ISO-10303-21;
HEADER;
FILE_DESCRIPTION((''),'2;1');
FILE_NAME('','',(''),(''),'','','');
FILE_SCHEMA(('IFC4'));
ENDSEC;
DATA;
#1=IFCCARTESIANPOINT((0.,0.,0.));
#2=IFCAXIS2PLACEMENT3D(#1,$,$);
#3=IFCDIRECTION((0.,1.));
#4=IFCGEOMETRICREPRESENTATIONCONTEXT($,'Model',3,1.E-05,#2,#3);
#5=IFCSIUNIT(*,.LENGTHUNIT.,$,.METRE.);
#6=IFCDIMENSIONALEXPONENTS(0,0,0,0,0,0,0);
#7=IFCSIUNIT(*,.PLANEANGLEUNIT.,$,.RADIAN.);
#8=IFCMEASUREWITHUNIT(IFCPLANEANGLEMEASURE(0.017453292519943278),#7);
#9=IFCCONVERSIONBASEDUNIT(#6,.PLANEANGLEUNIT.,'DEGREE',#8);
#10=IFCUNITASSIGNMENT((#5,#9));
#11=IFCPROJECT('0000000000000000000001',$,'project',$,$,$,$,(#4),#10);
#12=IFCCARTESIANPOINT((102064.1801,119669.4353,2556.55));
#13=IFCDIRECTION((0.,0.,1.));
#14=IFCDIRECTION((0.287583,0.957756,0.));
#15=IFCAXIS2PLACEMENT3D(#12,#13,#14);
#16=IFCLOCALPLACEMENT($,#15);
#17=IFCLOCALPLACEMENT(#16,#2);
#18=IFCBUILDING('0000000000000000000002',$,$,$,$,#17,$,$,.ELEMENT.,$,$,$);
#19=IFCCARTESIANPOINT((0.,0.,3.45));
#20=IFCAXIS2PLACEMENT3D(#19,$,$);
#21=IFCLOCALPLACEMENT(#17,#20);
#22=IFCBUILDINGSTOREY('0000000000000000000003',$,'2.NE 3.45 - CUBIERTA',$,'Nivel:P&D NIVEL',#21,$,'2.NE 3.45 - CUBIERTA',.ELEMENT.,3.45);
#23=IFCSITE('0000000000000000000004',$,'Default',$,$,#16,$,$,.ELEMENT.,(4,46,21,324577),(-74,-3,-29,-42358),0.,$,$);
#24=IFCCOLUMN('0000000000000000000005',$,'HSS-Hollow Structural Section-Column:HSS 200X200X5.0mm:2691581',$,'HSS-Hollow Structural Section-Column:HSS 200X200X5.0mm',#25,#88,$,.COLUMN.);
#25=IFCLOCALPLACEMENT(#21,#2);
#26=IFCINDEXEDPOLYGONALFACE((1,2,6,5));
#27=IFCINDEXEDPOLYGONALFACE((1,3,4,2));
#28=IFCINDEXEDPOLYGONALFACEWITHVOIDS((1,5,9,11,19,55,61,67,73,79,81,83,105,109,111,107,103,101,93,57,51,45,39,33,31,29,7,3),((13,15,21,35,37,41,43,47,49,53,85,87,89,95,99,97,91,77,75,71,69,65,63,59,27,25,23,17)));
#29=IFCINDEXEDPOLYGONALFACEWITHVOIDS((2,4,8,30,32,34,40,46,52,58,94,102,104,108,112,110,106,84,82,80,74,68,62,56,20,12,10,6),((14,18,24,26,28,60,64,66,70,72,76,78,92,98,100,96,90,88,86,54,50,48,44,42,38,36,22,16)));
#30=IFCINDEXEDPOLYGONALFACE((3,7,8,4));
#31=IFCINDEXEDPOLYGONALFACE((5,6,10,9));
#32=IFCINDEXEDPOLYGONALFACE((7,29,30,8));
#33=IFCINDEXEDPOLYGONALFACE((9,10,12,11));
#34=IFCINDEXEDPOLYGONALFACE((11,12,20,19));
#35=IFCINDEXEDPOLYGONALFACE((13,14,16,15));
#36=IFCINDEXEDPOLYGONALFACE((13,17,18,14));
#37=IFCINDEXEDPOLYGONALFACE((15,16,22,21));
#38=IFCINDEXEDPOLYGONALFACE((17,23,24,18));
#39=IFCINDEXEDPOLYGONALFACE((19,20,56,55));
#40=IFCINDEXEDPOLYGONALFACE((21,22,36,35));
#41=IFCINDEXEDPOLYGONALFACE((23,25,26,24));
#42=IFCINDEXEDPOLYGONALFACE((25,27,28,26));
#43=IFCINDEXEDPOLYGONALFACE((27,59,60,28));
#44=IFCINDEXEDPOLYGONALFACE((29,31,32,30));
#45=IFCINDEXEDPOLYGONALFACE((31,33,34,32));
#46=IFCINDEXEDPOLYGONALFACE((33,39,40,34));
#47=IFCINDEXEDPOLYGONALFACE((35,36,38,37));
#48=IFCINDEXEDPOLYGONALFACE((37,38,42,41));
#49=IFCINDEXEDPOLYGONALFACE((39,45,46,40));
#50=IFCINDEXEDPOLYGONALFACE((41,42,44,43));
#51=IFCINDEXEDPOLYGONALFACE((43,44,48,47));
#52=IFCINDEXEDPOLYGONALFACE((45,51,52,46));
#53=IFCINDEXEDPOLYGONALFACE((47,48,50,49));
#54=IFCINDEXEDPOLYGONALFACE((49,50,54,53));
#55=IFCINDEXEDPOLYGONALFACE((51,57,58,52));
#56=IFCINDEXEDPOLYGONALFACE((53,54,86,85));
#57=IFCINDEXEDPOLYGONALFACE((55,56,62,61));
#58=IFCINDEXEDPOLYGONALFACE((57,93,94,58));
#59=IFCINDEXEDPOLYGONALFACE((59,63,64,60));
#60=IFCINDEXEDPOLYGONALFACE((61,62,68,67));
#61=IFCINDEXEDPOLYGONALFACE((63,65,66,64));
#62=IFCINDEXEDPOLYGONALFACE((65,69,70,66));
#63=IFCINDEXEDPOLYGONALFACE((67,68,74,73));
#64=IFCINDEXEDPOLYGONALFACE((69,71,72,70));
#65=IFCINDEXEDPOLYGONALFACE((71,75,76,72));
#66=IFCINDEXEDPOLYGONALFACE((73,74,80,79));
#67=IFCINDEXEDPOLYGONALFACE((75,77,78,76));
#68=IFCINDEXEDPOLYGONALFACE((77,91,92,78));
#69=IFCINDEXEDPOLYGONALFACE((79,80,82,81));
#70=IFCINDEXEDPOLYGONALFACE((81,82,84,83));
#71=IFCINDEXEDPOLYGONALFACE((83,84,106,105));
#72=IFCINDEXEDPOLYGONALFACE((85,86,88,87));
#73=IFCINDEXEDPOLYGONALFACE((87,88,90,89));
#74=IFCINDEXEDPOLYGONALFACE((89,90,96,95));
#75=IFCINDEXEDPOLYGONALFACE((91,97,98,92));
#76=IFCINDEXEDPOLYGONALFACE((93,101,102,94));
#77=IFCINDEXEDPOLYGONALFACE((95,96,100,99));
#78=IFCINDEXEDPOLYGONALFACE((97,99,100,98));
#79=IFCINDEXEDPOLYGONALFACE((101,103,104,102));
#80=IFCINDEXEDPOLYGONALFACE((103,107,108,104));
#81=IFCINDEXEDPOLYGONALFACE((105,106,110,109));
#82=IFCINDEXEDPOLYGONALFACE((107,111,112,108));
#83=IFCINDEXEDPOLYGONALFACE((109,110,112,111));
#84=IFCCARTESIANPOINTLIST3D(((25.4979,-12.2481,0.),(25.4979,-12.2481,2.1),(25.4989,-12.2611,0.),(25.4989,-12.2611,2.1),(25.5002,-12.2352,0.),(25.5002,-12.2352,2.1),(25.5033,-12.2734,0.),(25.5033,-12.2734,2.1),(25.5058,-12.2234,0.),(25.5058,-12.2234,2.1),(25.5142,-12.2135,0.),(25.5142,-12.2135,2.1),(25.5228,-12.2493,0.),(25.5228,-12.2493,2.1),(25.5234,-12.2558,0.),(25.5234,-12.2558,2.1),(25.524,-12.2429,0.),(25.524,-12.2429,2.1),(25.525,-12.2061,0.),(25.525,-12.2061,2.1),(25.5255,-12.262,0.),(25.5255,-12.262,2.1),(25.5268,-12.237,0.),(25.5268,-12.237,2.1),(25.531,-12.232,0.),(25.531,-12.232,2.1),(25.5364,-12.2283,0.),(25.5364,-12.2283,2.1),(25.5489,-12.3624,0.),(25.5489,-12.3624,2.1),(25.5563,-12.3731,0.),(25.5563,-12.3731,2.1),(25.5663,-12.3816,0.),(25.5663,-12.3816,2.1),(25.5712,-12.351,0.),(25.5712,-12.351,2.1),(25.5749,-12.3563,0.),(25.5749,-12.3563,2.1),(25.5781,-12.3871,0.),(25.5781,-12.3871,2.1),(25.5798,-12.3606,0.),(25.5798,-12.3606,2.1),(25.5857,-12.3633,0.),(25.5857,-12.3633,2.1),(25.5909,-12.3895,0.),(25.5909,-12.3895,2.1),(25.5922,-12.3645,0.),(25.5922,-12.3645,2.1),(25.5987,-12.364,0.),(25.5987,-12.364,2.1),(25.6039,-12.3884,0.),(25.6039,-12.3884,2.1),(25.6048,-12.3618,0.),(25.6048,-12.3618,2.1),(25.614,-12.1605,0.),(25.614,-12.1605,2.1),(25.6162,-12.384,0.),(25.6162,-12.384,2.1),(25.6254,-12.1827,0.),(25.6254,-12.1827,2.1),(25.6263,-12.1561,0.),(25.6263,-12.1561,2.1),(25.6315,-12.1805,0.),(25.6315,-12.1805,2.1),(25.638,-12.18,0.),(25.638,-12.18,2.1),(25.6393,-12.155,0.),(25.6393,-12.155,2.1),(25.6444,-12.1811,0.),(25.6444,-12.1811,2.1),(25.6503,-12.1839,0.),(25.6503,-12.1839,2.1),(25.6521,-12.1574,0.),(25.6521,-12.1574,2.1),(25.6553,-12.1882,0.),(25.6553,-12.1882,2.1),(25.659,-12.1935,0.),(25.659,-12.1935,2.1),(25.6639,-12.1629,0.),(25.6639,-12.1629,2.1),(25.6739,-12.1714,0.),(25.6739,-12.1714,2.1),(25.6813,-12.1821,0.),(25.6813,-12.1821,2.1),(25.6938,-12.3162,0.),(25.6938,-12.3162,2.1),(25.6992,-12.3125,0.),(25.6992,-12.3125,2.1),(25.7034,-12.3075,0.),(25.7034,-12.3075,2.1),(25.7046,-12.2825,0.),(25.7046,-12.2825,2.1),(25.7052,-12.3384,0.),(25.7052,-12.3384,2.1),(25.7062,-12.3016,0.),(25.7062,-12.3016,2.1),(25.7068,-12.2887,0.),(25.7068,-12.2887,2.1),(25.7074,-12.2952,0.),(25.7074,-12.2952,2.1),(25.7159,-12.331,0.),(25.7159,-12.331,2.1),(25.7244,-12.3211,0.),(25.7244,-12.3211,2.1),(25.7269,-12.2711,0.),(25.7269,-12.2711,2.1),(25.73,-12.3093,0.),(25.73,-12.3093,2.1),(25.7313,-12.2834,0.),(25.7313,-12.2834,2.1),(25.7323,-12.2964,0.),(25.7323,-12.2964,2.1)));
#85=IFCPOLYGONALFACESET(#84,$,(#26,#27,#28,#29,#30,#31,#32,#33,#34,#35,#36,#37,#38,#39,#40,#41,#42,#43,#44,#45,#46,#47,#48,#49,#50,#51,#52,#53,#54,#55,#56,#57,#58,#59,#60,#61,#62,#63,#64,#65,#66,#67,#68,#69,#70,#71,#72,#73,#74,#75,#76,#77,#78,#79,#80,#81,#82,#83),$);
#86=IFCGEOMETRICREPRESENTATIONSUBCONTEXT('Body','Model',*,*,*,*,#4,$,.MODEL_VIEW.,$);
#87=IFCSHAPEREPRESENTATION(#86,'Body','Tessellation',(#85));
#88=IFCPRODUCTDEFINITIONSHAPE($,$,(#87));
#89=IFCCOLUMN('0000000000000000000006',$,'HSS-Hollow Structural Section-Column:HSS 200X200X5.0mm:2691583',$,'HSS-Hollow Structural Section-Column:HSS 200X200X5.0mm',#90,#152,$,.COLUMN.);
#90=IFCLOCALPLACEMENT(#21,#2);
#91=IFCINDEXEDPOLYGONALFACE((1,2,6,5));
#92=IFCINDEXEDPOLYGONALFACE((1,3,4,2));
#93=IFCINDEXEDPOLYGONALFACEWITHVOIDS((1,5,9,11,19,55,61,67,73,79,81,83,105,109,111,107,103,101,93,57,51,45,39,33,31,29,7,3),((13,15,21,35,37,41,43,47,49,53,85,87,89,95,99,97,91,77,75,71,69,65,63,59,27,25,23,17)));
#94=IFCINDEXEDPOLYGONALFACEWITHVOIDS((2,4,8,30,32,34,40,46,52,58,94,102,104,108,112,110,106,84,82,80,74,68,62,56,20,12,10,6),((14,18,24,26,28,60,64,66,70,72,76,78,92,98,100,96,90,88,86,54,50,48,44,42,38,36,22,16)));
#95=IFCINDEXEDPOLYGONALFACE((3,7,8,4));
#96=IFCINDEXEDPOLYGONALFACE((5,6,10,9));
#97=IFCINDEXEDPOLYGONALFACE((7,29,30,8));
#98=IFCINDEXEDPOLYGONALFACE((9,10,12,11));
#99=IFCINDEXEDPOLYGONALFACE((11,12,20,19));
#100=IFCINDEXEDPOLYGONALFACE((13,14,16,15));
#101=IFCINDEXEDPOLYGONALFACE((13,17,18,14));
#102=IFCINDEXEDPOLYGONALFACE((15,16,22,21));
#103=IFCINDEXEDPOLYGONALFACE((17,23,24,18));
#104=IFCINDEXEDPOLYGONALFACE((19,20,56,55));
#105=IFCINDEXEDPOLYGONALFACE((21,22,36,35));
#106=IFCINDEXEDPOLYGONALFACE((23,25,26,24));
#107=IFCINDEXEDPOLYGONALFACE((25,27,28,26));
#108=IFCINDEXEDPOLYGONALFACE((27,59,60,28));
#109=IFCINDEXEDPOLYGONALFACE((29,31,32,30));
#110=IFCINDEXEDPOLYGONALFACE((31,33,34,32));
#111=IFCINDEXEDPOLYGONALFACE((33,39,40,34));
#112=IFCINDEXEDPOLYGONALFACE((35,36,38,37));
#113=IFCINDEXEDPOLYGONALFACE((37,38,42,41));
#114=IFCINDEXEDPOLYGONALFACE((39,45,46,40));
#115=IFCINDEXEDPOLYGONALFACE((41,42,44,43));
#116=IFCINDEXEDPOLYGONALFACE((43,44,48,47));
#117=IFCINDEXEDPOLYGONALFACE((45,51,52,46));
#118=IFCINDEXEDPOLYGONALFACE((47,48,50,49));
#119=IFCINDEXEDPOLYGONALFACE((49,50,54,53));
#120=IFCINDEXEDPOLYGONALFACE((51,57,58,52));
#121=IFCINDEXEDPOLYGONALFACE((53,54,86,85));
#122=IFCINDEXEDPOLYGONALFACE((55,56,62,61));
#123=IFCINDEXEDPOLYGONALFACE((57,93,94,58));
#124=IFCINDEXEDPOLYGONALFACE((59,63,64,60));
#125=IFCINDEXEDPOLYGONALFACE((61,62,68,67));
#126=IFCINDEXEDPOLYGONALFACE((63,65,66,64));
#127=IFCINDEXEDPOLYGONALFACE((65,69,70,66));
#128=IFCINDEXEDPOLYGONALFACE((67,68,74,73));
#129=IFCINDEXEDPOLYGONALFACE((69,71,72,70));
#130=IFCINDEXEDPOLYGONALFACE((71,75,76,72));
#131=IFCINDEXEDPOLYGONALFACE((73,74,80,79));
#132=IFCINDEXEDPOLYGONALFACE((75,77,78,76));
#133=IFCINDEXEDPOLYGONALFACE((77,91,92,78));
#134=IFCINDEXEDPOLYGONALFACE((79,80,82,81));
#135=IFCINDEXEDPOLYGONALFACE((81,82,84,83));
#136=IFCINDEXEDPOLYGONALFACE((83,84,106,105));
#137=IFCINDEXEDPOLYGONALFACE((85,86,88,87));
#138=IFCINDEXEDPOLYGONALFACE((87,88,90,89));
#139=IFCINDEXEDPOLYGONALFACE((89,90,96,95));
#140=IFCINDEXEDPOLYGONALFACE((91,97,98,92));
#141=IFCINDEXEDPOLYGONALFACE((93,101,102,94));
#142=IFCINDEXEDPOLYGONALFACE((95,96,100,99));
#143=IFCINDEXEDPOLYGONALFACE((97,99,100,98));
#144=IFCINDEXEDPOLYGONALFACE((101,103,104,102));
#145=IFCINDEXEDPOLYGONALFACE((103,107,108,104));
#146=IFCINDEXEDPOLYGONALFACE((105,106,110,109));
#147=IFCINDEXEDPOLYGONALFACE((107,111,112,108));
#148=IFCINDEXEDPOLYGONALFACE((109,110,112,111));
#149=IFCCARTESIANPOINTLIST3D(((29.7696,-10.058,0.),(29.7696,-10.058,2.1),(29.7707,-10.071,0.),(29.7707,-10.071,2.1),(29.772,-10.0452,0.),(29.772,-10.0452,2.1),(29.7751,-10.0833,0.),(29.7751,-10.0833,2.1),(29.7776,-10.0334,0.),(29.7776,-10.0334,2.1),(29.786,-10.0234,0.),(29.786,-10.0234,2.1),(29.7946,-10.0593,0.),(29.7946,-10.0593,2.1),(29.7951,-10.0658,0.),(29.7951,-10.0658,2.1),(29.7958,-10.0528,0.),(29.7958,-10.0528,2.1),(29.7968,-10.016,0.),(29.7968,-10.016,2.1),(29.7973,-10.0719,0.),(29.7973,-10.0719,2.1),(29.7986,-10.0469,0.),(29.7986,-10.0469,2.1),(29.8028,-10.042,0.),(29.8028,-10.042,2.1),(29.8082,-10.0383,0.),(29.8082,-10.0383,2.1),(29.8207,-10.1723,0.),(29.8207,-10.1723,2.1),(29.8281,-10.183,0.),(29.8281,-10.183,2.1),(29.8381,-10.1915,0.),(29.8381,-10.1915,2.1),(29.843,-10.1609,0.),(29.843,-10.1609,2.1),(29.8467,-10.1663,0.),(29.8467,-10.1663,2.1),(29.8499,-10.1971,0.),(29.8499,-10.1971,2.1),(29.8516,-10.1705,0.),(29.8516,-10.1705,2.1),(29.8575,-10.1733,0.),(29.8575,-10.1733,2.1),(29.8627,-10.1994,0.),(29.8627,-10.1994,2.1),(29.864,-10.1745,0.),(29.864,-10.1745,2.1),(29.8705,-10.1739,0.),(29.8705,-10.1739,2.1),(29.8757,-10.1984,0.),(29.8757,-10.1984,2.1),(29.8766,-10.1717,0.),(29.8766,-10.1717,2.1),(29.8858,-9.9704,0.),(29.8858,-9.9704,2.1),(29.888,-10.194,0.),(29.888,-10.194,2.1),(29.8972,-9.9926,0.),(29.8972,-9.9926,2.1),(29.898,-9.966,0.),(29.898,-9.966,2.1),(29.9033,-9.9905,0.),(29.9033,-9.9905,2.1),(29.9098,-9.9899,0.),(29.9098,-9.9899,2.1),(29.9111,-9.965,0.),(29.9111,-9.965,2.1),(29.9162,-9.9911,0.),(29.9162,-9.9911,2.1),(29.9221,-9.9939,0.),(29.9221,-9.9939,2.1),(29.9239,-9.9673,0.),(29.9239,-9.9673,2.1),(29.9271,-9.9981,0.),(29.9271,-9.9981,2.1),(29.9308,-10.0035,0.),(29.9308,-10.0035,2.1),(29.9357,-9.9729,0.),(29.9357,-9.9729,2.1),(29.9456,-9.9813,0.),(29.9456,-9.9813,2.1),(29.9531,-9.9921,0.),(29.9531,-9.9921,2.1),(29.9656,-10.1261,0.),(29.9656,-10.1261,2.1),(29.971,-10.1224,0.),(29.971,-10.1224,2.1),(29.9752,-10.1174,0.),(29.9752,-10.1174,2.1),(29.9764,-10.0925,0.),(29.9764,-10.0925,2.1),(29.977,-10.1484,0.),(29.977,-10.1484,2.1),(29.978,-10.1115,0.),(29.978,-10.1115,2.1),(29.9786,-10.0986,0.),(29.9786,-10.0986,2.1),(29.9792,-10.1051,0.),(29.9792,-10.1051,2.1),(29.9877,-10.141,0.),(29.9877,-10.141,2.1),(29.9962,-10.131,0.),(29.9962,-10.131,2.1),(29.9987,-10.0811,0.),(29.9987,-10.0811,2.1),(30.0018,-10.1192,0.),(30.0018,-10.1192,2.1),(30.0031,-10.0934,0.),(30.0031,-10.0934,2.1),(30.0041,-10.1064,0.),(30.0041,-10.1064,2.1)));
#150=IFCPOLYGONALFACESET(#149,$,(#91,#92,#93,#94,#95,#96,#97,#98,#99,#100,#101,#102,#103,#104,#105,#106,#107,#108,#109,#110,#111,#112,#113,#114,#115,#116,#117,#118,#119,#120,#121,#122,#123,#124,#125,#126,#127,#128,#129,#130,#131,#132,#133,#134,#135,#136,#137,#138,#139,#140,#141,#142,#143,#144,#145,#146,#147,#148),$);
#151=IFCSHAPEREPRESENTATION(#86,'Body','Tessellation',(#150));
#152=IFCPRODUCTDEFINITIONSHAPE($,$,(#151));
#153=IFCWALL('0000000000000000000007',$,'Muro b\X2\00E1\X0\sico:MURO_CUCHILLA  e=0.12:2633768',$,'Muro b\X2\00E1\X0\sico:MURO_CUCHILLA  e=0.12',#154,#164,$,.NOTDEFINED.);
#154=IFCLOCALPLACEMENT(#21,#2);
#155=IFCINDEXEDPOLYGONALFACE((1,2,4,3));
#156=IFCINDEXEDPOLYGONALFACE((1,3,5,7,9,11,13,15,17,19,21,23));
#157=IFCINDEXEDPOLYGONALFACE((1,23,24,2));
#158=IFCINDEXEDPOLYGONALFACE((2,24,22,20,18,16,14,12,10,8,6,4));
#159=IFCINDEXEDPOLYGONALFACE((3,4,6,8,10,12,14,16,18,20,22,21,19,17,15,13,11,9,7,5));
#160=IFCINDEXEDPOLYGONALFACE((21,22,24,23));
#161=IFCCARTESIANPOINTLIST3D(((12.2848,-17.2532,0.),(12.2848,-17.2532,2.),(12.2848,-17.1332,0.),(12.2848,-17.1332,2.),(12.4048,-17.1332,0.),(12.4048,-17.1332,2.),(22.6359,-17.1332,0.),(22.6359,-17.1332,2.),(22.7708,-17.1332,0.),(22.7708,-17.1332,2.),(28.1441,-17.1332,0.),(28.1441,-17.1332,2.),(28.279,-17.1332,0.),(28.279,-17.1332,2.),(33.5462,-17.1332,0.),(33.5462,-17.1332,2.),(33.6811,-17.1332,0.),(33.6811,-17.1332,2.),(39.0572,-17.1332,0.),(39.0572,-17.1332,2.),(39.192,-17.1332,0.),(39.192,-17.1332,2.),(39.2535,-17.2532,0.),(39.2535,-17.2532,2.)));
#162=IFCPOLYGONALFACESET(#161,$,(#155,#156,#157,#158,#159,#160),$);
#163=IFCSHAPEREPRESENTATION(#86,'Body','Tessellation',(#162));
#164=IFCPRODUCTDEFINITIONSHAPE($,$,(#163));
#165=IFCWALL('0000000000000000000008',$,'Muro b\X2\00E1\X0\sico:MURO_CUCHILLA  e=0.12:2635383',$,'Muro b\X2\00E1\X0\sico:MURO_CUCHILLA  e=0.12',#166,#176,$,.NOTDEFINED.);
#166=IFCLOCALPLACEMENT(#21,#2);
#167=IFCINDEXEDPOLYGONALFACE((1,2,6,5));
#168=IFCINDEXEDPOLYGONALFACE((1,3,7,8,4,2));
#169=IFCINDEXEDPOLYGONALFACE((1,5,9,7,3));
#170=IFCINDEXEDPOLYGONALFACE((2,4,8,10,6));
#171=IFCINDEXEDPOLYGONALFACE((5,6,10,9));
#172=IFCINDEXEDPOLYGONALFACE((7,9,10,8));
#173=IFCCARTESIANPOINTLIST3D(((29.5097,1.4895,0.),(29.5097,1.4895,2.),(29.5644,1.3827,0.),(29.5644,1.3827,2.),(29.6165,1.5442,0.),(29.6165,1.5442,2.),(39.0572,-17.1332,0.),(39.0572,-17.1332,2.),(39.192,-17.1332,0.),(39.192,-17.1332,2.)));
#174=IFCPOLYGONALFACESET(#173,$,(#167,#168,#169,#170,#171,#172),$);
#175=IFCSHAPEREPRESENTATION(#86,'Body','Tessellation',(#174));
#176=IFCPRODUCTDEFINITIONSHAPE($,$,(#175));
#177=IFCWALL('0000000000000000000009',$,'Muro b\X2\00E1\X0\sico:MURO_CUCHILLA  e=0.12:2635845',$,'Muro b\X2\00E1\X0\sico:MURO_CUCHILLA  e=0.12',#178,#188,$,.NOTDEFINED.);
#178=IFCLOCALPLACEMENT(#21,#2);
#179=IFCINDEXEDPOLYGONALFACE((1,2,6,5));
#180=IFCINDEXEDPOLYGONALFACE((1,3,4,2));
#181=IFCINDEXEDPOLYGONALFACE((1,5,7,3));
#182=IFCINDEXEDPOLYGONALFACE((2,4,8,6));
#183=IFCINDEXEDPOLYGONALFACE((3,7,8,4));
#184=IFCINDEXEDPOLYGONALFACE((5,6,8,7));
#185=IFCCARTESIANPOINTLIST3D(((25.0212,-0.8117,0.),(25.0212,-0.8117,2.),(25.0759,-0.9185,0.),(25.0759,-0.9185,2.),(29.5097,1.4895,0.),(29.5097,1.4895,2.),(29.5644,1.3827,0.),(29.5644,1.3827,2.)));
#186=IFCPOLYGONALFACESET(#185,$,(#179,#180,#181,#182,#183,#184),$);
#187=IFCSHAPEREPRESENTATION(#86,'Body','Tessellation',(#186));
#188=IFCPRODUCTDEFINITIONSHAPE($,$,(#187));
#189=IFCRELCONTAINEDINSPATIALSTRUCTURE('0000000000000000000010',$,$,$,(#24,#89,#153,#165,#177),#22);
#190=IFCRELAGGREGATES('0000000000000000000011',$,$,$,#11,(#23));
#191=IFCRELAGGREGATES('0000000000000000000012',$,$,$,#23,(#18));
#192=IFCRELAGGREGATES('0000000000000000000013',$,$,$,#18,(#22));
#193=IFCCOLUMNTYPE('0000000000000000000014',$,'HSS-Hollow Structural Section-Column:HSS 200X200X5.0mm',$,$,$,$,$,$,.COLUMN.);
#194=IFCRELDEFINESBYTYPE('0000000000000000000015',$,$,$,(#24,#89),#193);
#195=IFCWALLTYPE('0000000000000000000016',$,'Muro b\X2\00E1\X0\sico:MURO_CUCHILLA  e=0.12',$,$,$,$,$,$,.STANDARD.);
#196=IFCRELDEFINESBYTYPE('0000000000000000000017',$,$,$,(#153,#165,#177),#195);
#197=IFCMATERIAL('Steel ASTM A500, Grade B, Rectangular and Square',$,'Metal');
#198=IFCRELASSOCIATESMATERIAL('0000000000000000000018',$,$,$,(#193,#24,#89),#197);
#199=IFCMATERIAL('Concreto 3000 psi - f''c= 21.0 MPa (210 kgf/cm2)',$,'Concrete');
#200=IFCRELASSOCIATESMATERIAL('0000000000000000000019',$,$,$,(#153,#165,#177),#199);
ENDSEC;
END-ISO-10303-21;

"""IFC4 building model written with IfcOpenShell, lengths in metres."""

from ifc_helpers import new_model, entity, si_unit, converted_unit, direction, frame, origin, place, context, subcontext, project, spatial, line, arc, indexed_curve, outline, extrude, source, transform, mapped, material, type_object, type_shapes, element, save


model = new_model("IFC4")

# Units and contexts
model_context = context("Model", 3, precision=1e-05, world=origin(), true_north=direction((0.0, 1.0)))
body_context = subcontext(model_context, "Body", "Model", "MODEL_VIEW")
ifc_project = project(units=[si_unit("LENGTHUNIT", "METRE"), converted_unit("PLANEANGLEUNIT", "DEGREE", entity("IfcPlaneAngleMeasure", 0.017453292519943278), si_unit("PLANEANGLEUNIT", "RADIAN"), dimensions=[0, 0, 0, 0, 0, 0, 0])], contexts=[model_context])

# Site, building, storey
site_placement = place(None, frame((102064.1801, 119669.4353, 2556.55), z_axis=(0.0, 0.0, 1.0), x_axis=(0.287583, 0.957756, 0.0)))
site = spatial("IfcSite", under=ifc_project, at=site_placement, Name="Default", CompositionType="ELEMENT", RefLatitude=(4, 46, 21, 324577), RefLongitude=(-74, -3, -29, -42358), RefElevation=0.0)
building_placement = place(site_placement, origin())
building = spatial("IfcBuilding", under=site, at=building_placement, CompositionType="ELEMENT")
storey_placement = place(building_placement, frame((0.0, 0.0, 3.45)))
storey = spatial("IfcBuildingStorey", under=building, at=storey_placement, Name="2.NE 3.45 - CUBIERTA", ObjectType="Nivel:P&D NIVEL", LongName="2.NE 3.45 - CUBIERTA", CompositionType="ELEMENT", Elevation=3.45)

# Columns
ifc_material_1 = material(Name="Steel ASTM A500, Grade B, Rectangular and Square", Category="Metal")
column_type_1 = type_object("IfcColumnType", Name="HSS-Hollow Structural Section-Column:HSS 200X200X5.0mm", PredefinedType="COLUMN", material=ifc_material_1)
shared_shape_1 = source(origin(), body_context, "Body", "SweptSolid", [
    extrude(outline(indexed_curve([(-0.05, -0.1), (0.05, -0.1), (0.0854, -0.0854), (0.1, -0.05), (0.1, 0.05), (0.0854, 0.0854), (0.05, 0.1), (-0.05, 0.1), (-0.0854, 0.0854), (-0.1, 0.05), (-0.1, -0.05), (-0.0854, -0.0854)], segments=[line(1, 2), arc(2, 3, 4), line(4, 5), arc(5, 6, 7), line(7, 8), arc(8, 9, 10), line(10, 11), arc(11, 12, 1)], self_intersect=False), holes=[indexed_curve([(-0.05, -0.075), (-0.0677, -0.0677), (-0.075, -0.05), (-0.075, 0.05), (-0.0677, 0.0677), (-0.05, 0.075), (0.05, 0.075), (0.0677, 0.0677), (0.075, 0.05), (0.075, -0.05), (0.0677, -0.0677), (0.05, -0.075)], segments=[arc(1, 2, 3), line(3, 4), arc(4, 5, 6), line(6, 7), arc(7, 8, 9), line(9, 10), arc(10, 11, 12), line(12, 1)], self_intersect=False)]), frame((0.0, 0.0, 3.45), z_axis=(0.0, 0.0, 1.0), x_axis=(-1.0, 0.0, 0.0)), (0.0, 0.0, 1.0), 2.1),
])
type_shapes(column_type_1, [shared_shape_1])
for number, where, z_axis, x_axis, name in (
    (1, (25.6151, -12.2722, -3.45), (0.0, 0.0, 1.0), (0.889869, 0.456217, 0.0), "HSS-Hollow Structural Section-Column:HSS 200X200X5.0mm:2691581"),
    (2, (29.8869, -10.0822, -3.45), (0.0, 0.0, 1.0), (0.889869, 0.456217, 0.0), "HSS-Hollow Structural Section-Column:HSS 200X200X5.0mm:2691583"),
):
    element("IfcColumn", number, at=place(storey_placement, frame(where, z_axis=z_axis, x_axis=x_axis)), inside=storey, type_object=column_type_1, material=ifc_material_1, Name=name, ObjectType="HSS-Hollow Structural Section-Column:HSS 200X200X5.0mm", PredefinedType="COLUMN", context=body_context, shape_type="MappedRepresentation", body=[
        mapped(shared_shape_1, transform((0.0, 0.0, 0.0), scale=1.0)),
    ])

# Walls
ifc_material_2 = material(Name="Concreto 3000 psi - f'c= 21.0 MPa (210 kgf/cm2)", Category="Concrete")
wall_type = type_object("IfcWallType", Name="Muro básico:MURO_CUCHILLA  e=0.12", PredefinedType="STANDARD")
wall_1_placement = place(storey_placement, frame((39.2535, -17.1932, 0.0), z_axis=(0.0, 0.0, 1.0), x_axis=(-1.0, 0.0, 0.0)))
element("IfcWall", 3, at=wall_1_placement, inside=storey, type_object=wall_type, material=ifc_material_2, Name="Muro básico:MURO_CUCHILLA  e=0.12:2633768", ObjectType="Muro básico:MURO_CUCHILLA  e=0.12", PredefinedType="NOTDEFINED", context=body_context, shape_type="SweptSolid", body=[
    extrude(outline(indexed_curve([(26.9688, -0.06), (26.9688, 0.06), (0.0, 0.06), (0.0615, -0.06), (0.1964, -0.06), (5.5724, -0.06), (5.7073, -0.06), (10.9745, -0.06), (11.1094, -0.06), (16.4828, -0.06), (16.6176, -0.06), (26.8488, -0.06), (26.9688, -0.06)], self_intersect=False)), origin(), (0.0, 0.0, 1.0), 2.0),
])
wall_2_placement = place(storey_placement, frame((29.5631, 1.5168, 0.0), z_axis=(0.0, 0.0, 1.0), x_axis=(0.456217, -0.889869, 0.0)))
element("IfcWall", 4, at=wall_2_placement, inside=storey, type_object=wall_type, material=ifc_material_2, Name="Muro básico:MURO_CUCHILLA  e=0.12:2635383", ObjectType="Muro básico:MURO_CUCHILLA  e=0.12", PredefinedType="NOTDEFINED", context=body_context, shape_type="SweptSolid", body=[
    extrude(outline(indexed_curve([(20.9275, -0.06), (20.989, 0.06), (0.0, 0.06), (0.0, -0.06), (0.12, -0.06), (20.9275, -0.06)], self_intersect=False)), origin(), (0.0, 0.0, 1.0), 2.0),
])
wall_3_placement = place(storey_placement, frame((29.5371, 1.4361, 0.0), z_axis=(0.0, 0.0, 1.0), x_axis=(-0.889869, -0.456217, 0.0)))
element("IfcWall", 5, at=wall_3_placement, inside=storey, type_object=wall_type, material=ifc_material_2, Name="Muro básico:MURO_CUCHILLA  e=0.12:2635845", ObjectType="Muro básico:MURO_CUCHILLA  e=0.12", PredefinedType="NOTDEFINED", context=body_context, shape_type="SweptSolid", body=[
    extrude(outline(indexed_curve([(5.044, 0.06), (0.0, 0.06), (0.0, -0.06), (5.044, -0.06), (5.044, 0.06)], self_intersect=False)), origin(), (0.0, 0.0, 1.0), 2.0),
])

save(model, "model.ifc")
